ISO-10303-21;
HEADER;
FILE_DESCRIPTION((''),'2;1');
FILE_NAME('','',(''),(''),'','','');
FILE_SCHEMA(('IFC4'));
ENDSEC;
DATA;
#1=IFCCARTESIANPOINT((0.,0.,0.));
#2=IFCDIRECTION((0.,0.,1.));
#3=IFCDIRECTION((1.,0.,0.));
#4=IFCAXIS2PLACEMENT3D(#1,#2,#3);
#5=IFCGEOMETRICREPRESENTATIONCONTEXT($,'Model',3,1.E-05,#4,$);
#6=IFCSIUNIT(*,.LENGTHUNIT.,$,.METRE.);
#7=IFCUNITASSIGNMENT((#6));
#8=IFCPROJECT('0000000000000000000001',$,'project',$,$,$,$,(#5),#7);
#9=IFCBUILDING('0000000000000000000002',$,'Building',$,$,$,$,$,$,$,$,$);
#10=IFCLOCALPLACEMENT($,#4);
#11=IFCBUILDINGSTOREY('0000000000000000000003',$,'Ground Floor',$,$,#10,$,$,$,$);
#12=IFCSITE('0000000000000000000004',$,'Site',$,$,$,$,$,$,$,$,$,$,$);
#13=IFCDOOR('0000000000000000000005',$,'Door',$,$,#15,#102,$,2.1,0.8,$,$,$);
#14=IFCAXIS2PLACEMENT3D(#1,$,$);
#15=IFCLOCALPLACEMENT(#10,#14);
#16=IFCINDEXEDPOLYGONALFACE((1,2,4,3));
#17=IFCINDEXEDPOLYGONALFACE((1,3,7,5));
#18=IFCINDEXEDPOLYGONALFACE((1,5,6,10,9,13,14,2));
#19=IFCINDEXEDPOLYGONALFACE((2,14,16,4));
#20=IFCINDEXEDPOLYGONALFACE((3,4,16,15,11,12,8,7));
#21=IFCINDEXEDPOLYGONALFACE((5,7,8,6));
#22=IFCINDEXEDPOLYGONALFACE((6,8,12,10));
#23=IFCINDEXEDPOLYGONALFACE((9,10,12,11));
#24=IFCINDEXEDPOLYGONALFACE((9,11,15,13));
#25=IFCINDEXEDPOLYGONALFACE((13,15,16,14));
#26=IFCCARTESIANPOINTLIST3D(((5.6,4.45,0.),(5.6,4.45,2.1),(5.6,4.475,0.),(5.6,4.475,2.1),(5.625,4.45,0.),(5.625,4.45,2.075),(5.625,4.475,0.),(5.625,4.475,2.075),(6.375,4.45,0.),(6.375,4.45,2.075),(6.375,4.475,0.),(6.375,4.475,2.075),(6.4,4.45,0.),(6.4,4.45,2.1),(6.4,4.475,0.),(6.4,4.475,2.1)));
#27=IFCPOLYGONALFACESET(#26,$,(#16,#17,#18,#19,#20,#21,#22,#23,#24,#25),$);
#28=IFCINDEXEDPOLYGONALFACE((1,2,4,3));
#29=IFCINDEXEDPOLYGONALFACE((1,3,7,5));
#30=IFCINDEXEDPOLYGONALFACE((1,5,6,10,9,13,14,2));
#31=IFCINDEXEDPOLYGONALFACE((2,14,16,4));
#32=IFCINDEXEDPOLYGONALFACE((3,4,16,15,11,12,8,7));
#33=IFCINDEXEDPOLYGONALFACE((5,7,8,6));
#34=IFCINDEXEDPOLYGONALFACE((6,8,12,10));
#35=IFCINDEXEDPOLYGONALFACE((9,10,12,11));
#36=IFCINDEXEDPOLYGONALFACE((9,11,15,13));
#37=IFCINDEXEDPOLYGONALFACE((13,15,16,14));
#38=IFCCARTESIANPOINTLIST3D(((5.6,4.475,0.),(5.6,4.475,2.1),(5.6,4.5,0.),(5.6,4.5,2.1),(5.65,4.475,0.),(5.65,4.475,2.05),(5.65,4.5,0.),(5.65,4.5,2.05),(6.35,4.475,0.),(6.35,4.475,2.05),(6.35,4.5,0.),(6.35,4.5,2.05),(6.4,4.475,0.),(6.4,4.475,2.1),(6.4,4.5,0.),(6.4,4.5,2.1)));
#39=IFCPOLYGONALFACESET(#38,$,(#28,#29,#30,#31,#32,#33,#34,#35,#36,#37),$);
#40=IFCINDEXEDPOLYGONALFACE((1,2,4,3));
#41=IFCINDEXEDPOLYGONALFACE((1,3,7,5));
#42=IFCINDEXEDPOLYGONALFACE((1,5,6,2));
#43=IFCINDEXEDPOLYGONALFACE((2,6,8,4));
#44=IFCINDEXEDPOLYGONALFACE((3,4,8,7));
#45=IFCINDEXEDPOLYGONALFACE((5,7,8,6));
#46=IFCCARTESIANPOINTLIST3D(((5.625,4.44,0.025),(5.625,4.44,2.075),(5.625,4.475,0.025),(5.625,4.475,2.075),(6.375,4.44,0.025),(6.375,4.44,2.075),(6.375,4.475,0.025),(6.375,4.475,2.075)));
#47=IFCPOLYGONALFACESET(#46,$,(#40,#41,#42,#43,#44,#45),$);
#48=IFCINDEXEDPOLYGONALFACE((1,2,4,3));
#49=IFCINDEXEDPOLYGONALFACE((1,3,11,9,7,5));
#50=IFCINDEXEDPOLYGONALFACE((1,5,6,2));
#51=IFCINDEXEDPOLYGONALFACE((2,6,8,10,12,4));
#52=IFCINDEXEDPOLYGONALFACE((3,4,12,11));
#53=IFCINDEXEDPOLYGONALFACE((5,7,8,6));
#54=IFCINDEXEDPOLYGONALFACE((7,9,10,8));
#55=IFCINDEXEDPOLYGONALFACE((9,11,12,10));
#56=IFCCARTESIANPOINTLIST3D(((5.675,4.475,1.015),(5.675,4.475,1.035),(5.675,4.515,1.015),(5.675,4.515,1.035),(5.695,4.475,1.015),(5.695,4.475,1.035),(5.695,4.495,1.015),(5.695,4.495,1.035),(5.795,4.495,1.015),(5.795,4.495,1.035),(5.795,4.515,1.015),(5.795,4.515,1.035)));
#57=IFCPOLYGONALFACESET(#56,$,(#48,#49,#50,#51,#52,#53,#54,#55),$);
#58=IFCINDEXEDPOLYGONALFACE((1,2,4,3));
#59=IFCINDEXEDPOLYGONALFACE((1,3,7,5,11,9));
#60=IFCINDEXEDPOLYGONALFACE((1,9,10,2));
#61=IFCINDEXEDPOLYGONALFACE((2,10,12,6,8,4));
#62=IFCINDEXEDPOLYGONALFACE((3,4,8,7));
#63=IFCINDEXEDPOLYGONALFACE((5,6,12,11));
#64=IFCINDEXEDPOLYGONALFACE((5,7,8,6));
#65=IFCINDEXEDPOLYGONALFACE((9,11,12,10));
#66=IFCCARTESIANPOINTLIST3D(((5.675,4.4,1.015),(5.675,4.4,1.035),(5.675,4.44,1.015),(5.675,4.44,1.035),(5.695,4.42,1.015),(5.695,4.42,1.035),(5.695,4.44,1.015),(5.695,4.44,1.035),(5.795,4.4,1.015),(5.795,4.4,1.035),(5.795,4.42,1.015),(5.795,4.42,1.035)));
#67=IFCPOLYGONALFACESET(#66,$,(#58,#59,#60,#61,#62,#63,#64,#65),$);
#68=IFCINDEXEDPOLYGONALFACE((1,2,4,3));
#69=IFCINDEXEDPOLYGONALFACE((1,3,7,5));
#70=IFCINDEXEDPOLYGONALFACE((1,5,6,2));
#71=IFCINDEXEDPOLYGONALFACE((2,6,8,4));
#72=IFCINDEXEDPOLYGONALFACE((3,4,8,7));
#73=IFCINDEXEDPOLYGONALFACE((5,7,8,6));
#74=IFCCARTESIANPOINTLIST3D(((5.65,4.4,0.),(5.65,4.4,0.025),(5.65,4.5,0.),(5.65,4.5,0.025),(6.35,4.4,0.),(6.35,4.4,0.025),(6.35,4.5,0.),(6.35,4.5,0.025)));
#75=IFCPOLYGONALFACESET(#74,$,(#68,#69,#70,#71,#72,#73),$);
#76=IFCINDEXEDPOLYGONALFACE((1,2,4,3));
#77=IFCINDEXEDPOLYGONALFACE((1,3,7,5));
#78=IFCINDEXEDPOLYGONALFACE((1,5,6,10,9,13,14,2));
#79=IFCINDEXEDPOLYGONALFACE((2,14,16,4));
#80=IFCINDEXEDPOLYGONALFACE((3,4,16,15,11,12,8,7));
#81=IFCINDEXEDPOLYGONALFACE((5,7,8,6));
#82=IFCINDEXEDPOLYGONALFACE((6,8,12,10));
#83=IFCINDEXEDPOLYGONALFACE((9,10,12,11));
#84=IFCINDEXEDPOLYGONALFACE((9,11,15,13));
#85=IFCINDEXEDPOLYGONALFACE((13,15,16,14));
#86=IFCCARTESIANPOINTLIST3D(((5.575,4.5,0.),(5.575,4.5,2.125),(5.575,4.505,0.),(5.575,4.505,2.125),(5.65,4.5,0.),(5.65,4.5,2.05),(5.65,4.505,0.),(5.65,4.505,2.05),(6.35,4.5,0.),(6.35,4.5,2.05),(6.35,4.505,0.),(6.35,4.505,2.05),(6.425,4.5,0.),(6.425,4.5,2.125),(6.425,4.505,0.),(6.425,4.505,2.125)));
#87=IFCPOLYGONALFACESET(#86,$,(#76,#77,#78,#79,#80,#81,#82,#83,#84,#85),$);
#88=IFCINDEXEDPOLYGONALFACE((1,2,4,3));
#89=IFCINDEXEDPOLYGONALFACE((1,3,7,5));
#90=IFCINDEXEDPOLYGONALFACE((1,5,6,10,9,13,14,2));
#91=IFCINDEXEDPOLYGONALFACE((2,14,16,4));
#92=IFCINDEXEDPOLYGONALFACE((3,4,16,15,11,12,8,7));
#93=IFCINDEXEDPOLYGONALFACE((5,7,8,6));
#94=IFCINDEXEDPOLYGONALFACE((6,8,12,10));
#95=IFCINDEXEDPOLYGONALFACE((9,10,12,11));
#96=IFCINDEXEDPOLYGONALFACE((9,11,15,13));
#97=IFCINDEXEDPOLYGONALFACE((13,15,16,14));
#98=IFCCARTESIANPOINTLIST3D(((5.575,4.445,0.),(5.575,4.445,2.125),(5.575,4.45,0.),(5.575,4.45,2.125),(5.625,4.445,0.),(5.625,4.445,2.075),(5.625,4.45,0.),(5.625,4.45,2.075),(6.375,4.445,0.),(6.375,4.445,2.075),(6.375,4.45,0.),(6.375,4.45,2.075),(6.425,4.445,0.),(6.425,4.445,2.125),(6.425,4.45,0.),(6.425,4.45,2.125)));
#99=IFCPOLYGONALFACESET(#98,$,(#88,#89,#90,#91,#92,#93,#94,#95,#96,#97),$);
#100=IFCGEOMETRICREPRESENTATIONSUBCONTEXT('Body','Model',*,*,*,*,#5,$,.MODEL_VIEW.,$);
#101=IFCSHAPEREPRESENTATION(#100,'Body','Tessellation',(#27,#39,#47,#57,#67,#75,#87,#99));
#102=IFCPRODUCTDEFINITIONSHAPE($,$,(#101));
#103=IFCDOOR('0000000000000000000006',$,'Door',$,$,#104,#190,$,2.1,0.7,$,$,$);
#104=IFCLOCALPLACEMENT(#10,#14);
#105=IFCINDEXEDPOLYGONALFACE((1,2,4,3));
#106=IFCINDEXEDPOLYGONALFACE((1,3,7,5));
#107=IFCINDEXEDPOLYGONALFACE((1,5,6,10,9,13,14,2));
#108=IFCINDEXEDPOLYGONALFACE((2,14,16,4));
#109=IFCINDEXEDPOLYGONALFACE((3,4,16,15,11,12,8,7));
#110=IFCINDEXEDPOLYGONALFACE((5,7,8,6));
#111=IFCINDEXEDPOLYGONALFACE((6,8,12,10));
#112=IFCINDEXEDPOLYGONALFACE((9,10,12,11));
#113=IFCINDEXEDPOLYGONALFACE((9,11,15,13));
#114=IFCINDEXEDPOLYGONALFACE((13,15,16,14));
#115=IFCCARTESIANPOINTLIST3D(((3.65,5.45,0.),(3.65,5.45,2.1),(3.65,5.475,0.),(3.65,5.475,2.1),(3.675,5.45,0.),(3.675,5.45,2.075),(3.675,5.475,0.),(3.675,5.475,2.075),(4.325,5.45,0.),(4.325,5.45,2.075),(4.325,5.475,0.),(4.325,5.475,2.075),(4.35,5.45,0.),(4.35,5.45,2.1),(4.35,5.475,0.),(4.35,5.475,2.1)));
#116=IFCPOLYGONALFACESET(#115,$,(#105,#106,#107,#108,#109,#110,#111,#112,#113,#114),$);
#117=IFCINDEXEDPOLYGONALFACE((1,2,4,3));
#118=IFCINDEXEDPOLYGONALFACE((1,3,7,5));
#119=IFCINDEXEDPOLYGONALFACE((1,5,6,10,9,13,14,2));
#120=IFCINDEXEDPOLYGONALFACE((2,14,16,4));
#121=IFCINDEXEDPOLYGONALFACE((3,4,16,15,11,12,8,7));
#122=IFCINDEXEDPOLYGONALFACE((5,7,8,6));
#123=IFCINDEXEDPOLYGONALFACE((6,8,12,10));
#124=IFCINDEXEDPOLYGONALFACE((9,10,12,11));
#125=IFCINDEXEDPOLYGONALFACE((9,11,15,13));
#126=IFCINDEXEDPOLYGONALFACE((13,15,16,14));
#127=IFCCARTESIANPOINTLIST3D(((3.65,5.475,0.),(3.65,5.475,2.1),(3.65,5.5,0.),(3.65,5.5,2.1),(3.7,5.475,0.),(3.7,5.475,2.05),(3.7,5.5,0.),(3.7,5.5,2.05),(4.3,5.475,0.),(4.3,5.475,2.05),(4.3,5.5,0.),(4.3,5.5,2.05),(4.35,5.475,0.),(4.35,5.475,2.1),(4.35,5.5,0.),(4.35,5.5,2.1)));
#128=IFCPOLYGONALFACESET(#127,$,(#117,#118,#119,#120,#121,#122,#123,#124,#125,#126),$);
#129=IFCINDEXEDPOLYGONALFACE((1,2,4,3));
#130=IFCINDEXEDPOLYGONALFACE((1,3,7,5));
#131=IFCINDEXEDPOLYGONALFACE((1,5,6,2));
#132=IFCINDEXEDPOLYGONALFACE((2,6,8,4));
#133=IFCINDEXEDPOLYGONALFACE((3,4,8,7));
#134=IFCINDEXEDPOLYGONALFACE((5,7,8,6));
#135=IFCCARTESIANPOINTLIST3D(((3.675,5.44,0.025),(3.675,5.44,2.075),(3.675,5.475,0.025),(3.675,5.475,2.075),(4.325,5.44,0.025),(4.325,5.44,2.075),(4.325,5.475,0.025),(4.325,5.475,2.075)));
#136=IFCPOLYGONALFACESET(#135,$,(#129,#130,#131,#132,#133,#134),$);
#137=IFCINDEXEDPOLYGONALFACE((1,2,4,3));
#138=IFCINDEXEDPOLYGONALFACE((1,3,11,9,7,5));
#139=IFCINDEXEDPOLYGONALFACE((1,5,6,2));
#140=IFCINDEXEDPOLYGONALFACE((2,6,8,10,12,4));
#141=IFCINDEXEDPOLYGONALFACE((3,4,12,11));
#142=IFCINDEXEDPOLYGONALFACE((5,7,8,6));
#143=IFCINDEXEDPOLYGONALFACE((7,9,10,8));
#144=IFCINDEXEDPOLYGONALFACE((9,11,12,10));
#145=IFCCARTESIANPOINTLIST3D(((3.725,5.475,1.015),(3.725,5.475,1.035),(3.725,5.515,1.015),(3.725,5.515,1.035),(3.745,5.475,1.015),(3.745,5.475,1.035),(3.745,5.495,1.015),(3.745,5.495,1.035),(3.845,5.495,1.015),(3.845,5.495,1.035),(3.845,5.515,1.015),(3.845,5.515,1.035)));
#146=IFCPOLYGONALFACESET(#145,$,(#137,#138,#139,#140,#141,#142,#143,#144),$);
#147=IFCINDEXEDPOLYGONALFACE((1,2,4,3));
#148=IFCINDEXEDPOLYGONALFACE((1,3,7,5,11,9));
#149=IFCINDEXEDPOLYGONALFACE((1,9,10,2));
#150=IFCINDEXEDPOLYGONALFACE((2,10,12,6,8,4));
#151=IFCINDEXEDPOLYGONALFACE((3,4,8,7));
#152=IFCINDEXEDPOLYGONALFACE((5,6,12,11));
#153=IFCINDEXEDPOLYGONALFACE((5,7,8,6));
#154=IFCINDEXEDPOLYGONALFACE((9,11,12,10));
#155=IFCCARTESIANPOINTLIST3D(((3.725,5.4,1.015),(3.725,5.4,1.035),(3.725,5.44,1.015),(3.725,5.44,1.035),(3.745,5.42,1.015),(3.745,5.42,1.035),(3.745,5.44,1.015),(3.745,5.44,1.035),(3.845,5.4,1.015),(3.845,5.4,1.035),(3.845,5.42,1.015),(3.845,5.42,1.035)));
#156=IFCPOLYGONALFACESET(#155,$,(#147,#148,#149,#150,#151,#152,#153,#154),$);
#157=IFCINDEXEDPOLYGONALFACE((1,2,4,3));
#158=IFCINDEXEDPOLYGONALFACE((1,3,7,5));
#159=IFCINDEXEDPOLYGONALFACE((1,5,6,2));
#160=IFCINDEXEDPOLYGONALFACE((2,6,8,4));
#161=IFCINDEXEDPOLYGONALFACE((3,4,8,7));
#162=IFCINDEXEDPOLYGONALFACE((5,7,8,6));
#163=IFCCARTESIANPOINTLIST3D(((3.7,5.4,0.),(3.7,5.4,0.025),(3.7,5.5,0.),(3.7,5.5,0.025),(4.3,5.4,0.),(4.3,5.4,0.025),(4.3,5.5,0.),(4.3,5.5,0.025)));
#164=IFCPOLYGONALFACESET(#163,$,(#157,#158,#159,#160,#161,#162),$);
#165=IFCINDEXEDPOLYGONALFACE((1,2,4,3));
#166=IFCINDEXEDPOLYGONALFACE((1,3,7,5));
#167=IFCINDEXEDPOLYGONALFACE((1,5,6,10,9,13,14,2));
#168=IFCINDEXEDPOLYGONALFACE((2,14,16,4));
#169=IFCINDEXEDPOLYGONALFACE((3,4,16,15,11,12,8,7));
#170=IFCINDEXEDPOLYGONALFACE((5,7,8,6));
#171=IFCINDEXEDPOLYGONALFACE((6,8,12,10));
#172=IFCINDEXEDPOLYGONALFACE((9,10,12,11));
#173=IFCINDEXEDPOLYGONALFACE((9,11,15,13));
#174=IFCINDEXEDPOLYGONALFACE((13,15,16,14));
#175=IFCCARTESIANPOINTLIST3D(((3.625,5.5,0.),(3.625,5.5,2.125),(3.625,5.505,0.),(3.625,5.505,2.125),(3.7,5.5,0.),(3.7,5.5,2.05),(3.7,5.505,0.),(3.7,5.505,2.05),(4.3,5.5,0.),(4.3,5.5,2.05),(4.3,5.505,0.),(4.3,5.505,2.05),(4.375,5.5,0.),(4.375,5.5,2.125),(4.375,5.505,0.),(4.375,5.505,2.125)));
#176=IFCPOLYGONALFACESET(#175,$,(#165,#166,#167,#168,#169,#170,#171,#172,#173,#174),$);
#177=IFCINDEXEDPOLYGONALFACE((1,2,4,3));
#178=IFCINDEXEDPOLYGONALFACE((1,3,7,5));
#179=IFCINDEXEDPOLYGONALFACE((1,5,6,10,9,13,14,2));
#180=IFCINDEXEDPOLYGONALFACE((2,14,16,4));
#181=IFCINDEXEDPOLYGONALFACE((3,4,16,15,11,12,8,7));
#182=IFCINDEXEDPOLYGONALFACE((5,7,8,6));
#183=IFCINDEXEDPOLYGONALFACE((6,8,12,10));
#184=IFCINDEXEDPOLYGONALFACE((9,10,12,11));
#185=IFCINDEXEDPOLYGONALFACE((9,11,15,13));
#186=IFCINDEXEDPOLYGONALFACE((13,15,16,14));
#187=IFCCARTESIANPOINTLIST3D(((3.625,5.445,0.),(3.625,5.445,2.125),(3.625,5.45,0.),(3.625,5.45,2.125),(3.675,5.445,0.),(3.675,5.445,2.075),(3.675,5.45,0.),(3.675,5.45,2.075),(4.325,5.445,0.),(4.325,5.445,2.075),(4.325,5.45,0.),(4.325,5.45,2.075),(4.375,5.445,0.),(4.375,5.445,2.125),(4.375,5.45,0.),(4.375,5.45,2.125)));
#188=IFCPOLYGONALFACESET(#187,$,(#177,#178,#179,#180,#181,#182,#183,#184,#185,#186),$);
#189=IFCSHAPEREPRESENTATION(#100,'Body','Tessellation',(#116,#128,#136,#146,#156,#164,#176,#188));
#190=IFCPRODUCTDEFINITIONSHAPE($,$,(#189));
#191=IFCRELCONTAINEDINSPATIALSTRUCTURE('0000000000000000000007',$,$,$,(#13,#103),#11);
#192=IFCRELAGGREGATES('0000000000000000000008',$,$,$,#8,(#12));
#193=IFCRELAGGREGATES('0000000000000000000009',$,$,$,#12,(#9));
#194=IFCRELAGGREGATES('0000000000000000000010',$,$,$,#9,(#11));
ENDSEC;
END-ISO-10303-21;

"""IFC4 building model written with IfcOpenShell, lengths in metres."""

from ifc_helpers import new_model, si_unit, frame, origin_with_axes, place, context, subcontext, project, spatial, line, indexed_curve, outline, extrude, element, save


model = new_model("IFC4")

# Units and contexts
model_context = context("Model", 3, precision=1e-05, world=origin_with_axes())
body_context = subcontext(model_context, "Body", "Model", "MODEL_VIEW")
ifc_project = project(units=[si_unit("LENGTHUNIT", "METRE")], contexts=[model_context])

# Site, building, storey
site = spatial("IfcSite", under=ifc_project, Name="Site")
building = spatial("IfcBuilding", under=site, Name="Building")
storey_placement = place(None, origin_with_axes())
storey = spatial("IfcBuildingStorey", under=building, at=storey_placement, Name="Ground Floor")

# Doors
door_1_placement = place(storey_placement, frame((6.4, 4.5, 0.0), z_axis=(0.0, 0.0, 1.0), x_axis=(-1.0, 0.0, 0.0)))
element("IfcDoor", 1, at=door_1_placement, inside=storey, Name="Door", OverallHeight=2.1, OverallWidth=0.8, context=body_context, shape_type="SweptSolid", body=[
    extrude(outline(indexed_curve([(0.0, 0.0), (0.0, 2.1), (0.8, 2.1), (0.8, 0.0), (0.775, 0.0), (0.775, 2.075), (0.025, 2.075), (0.025, 0.0)], segments=[line(1, 2, 3, 4, 5, 6, 7, 8, 1)])), frame((0.0, 0.025, 0.0), z_axis=(0.0, -1.0, 0.0), x_axis=(1.0, 0.0, 0.0)), (0.0, 0.0, -1.0), 0.025),
    extrude(outline(indexed_curve([(0.0, 0.0), (0.0, 2.1), (0.8, 2.1), (0.8, 0.0), (0.75, 0.0), (0.75, 2.05), (0.05, 2.05), (0.05, 0.0)], segments=[line(1, 2, 3, 4, 5, 6, 7, 8, 1)])), frame((0.0, 0.0, 0.0), z_axis=(0.0, -1.0, 0.0), x_axis=(1.0, 0.0, 0.0)), (0.0, 0.0, -1.0), 0.025),
    extrude(outline(indexed_curve([(0.0, 0.0), (0.75, 0.0), (0.75, 0.035), (0.0, 0.035)], segments=[line(1, 2, 3, 4, 1)])), frame((0.025, 0.025, 0.025), z_axis=(0.0, 0.0, 1.0), x_axis=(1.0, 0.0, 0.0)), (0.0, 0.0, 1.0), 2.05),
    extrude(outline(indexed_curve([(0.0, 0.0), (0.0, -0.04), (-0.12, -0.04), (-0.12, -0.02), (-0.02, -0.02), (-0.02, 0.0)], segments=[line(1, 2, 3, 4, 5, 6, 1)])), frame((0.725, 0.025, 1.015), z_axis=(0.0, 0.0, 1.0), x_axis=(1.0, 0.0, 0.0)), (0.0, 0.0, 1.0), 0.02),
    extrude(outline(indexed_curve([(0.0, 0.0), (0.0, 0.04), (-0.12, 0.04), (-0.12, 0.02), (-0.02, 0.02), (-0.02, 0.0)], segments=[line(1, 2, 3, 4, 5, 6, 1)])), frame((0.725, 0.06, 1.015), z_axis=(0.0, 0.0, 1.0), x_axis=(1.0, 0.0, 0.0)), (0.0, 0.0, 1.0), 0.02),
    extrude(outline(indexed_curve([(0.0, 0.0), (0.7, 0.0), (0.7, 0.1), (0.0, 0.1)], segments=[line(1, 2, 3, 4, 1)])), frame((0.05, 0.0, 0.0), z_axis=(0.0, 0.0, 1.0), x_axis=(1.0, 0.0, 0.0)), (0.0, 0.0, 1.0), 0.025),
    extrude(outline(indexed_curve([(0.0, 0.0), (0.0, 2.125), (0.85, 2.125), (0.85, 0.0), (0.775, 0.0), (0.775, 2.05), (0.075, 2.05), (0.075, 0.0)], segments=[line(1, 2, 3, 4, 5, 6, 7, 8, 1)])), frame((-0.025, -0.005, 0.0), z_axis=(0.0, -1.0, 0.0), x_axis=(1.0, 0.0, 0.0)), (0.0, 0.0, -1.0), 0.005),
    extrude(outline(indexed_curve([(0.0, 0.0), (0.0, 2.125), (0.85, 2.125), (0.85, 0.0), (0.8, 0.0), (0.8, 2.075), (0.05, 2.075), (0.05, 0.0)], segments=[line(1, 2, 3, 4, 5, 6, 7, 8, 1)])), frame((-0.025, 0.05, 0.0), z_axis=(0.0, -1.0, 0.0), x_axis=(1.0, 0.0, 0.0)), (0.0, 0.0, -1.0), 0.005),
])
door_2_placement = place(storey_placement, frame((4.35, 5.5, 0.0), z_axis=(0.0, 0.0, 1.0), x_axis=(-1.0, 0.0, 0.0)))
element("IfcDoor", 2, at=door_2_placement, inside=storey, Name="Door", OverallHeight=2.1, OverallWidth=0.7, context=body_context, shape_type="SweptSolid", body=[
    extrude(outline(indexed_curve([(0.0, 0.0), (0.0, 2.1), (0.7, 2.1), (0.7, 0.0), (0.675, 0.0), (0.675, 2.075), (0.025, 2.075), (0.025, 0.0)], segments=[line(1, 2, 3, 4, 5, 6, 7, 8, 1)])), frame((0.0, 0.025, 0.0), z_axis=(0.0, -1.0, 0.0), x_axis=(1.0, 0.0, 0.0)), (0.0, 0.0, -1.0), 0.025),
    extrude(outline(indexed_curve([(0.0, 0.0), (0.0, 2.1), (0.7, 2.1), (0.7, 0.0), (0.65, 0.0), (0.65, 2.05), (0.05, 2.05), (0.05, 0.0)], segments=[line(1, 2, 3, 4, 5, 6, 7, 8, 1)])), frame((0.0, 0.0, 0.0), z_axis=(0.0, -1.0, 0.0), x_axis=(1.0, 0.0, 0.0)), (0.0, 0.0, -1.0), 0.025),
    extrude(outline(indexed_curve([(0.0, 0.0), (0.65, 0.0), (0.65, 0.035), (0.0, 0.035)], segments=[line(1, 2, 3, 4, 1)])), frame((0.025, 0.025, 0.025), z_axis=(0.0, 0.0, 1.0), x_axis=(1.0, 0.0, 0.0)), (0.0, 0.0, 1.0), 2.05),
    extrude(outline(indexed_curve([(0.0, 0.0), (0.0, -0.04), (-0.12, -0.04), (-0.12, -0.02), (-0.02, -0.02), (-0.02, 0.0)], segments=[line(1, 2, 3, 4, 5, 6, 1)])), frame((0.625, 0.025, 1.015), z_axis=(0.0, 0.0, 1.0), x_axis=(1.0, 0.0, 0.0)), (0.0, 0.0, 1.0), 0.02),
    extrude(outline(indexed_curve([(0.0, 0.0), (0.0, 0.04), (-0.12, 0.04), (-0.12, 0.02), (-0.02, 0.02), (-0.02, 0.0)], segments=[line(1, 2, 3, 4, 5, 6, 1)])), frame((0.625, 0.06, 1.015), z_axis=(0.0, 0.0, 1.0), x_axis=(1.0, 0.0, 0.0)), (0.0, 0.0, 1.0), 0.02),
    extrude(outline(indexed_curve([(0.0, 0.0), (0.6, 0.0), (0.6, 0.1), (0.0, 0.1)], segments=[line(1, 2, 3, 4, 1)])), frame((0.05, 0.0, 0.0), z_axis=(0.0, 0.0, 1.0), x_axis=(1.0, 0.0, 0.0)), (0.0, 0.0, 1.0), 0.025),
    extrude(outline(indexed_curve([(0.0, 0.0), (0.0, 2.125), (0.75, 2.125), (0.75, 0.0), (0.675, 0.0), (0.675, 2.05), (0.075, 2.05), (0.075, 0.0)], segments=[line(1, 2, 3, 4, 5, 6, 7, 8, 1)])), frame((-0.025, -0.005, 0.0), z_axis=(0.0, -1.0, 0.0), x_axis=(1.0, 0.0, 0.0)), (0.0, 0.0, -1.0), 0.005),
    extrude(outline(indexed_curve([(0.0, 0.0), (0.0, 2.125), (0.75, 2.125), (0.75, 0.0), (0.7, 0.0), (0.7, 2.075), (0.05, 2.075), (0.05, 0.0)], segments=[line(1, 2, 3, 4, 5, 6, 7, 8, 1)])), frame((-0.025, 0.05, 0.0), z_axis=(0.0, -1.0, 0.0), x_axis=(1.0, 0.0, 0.0)), (0.0, 0.0, -1.0), 0.005),
])

save(model, "model.ifc")
